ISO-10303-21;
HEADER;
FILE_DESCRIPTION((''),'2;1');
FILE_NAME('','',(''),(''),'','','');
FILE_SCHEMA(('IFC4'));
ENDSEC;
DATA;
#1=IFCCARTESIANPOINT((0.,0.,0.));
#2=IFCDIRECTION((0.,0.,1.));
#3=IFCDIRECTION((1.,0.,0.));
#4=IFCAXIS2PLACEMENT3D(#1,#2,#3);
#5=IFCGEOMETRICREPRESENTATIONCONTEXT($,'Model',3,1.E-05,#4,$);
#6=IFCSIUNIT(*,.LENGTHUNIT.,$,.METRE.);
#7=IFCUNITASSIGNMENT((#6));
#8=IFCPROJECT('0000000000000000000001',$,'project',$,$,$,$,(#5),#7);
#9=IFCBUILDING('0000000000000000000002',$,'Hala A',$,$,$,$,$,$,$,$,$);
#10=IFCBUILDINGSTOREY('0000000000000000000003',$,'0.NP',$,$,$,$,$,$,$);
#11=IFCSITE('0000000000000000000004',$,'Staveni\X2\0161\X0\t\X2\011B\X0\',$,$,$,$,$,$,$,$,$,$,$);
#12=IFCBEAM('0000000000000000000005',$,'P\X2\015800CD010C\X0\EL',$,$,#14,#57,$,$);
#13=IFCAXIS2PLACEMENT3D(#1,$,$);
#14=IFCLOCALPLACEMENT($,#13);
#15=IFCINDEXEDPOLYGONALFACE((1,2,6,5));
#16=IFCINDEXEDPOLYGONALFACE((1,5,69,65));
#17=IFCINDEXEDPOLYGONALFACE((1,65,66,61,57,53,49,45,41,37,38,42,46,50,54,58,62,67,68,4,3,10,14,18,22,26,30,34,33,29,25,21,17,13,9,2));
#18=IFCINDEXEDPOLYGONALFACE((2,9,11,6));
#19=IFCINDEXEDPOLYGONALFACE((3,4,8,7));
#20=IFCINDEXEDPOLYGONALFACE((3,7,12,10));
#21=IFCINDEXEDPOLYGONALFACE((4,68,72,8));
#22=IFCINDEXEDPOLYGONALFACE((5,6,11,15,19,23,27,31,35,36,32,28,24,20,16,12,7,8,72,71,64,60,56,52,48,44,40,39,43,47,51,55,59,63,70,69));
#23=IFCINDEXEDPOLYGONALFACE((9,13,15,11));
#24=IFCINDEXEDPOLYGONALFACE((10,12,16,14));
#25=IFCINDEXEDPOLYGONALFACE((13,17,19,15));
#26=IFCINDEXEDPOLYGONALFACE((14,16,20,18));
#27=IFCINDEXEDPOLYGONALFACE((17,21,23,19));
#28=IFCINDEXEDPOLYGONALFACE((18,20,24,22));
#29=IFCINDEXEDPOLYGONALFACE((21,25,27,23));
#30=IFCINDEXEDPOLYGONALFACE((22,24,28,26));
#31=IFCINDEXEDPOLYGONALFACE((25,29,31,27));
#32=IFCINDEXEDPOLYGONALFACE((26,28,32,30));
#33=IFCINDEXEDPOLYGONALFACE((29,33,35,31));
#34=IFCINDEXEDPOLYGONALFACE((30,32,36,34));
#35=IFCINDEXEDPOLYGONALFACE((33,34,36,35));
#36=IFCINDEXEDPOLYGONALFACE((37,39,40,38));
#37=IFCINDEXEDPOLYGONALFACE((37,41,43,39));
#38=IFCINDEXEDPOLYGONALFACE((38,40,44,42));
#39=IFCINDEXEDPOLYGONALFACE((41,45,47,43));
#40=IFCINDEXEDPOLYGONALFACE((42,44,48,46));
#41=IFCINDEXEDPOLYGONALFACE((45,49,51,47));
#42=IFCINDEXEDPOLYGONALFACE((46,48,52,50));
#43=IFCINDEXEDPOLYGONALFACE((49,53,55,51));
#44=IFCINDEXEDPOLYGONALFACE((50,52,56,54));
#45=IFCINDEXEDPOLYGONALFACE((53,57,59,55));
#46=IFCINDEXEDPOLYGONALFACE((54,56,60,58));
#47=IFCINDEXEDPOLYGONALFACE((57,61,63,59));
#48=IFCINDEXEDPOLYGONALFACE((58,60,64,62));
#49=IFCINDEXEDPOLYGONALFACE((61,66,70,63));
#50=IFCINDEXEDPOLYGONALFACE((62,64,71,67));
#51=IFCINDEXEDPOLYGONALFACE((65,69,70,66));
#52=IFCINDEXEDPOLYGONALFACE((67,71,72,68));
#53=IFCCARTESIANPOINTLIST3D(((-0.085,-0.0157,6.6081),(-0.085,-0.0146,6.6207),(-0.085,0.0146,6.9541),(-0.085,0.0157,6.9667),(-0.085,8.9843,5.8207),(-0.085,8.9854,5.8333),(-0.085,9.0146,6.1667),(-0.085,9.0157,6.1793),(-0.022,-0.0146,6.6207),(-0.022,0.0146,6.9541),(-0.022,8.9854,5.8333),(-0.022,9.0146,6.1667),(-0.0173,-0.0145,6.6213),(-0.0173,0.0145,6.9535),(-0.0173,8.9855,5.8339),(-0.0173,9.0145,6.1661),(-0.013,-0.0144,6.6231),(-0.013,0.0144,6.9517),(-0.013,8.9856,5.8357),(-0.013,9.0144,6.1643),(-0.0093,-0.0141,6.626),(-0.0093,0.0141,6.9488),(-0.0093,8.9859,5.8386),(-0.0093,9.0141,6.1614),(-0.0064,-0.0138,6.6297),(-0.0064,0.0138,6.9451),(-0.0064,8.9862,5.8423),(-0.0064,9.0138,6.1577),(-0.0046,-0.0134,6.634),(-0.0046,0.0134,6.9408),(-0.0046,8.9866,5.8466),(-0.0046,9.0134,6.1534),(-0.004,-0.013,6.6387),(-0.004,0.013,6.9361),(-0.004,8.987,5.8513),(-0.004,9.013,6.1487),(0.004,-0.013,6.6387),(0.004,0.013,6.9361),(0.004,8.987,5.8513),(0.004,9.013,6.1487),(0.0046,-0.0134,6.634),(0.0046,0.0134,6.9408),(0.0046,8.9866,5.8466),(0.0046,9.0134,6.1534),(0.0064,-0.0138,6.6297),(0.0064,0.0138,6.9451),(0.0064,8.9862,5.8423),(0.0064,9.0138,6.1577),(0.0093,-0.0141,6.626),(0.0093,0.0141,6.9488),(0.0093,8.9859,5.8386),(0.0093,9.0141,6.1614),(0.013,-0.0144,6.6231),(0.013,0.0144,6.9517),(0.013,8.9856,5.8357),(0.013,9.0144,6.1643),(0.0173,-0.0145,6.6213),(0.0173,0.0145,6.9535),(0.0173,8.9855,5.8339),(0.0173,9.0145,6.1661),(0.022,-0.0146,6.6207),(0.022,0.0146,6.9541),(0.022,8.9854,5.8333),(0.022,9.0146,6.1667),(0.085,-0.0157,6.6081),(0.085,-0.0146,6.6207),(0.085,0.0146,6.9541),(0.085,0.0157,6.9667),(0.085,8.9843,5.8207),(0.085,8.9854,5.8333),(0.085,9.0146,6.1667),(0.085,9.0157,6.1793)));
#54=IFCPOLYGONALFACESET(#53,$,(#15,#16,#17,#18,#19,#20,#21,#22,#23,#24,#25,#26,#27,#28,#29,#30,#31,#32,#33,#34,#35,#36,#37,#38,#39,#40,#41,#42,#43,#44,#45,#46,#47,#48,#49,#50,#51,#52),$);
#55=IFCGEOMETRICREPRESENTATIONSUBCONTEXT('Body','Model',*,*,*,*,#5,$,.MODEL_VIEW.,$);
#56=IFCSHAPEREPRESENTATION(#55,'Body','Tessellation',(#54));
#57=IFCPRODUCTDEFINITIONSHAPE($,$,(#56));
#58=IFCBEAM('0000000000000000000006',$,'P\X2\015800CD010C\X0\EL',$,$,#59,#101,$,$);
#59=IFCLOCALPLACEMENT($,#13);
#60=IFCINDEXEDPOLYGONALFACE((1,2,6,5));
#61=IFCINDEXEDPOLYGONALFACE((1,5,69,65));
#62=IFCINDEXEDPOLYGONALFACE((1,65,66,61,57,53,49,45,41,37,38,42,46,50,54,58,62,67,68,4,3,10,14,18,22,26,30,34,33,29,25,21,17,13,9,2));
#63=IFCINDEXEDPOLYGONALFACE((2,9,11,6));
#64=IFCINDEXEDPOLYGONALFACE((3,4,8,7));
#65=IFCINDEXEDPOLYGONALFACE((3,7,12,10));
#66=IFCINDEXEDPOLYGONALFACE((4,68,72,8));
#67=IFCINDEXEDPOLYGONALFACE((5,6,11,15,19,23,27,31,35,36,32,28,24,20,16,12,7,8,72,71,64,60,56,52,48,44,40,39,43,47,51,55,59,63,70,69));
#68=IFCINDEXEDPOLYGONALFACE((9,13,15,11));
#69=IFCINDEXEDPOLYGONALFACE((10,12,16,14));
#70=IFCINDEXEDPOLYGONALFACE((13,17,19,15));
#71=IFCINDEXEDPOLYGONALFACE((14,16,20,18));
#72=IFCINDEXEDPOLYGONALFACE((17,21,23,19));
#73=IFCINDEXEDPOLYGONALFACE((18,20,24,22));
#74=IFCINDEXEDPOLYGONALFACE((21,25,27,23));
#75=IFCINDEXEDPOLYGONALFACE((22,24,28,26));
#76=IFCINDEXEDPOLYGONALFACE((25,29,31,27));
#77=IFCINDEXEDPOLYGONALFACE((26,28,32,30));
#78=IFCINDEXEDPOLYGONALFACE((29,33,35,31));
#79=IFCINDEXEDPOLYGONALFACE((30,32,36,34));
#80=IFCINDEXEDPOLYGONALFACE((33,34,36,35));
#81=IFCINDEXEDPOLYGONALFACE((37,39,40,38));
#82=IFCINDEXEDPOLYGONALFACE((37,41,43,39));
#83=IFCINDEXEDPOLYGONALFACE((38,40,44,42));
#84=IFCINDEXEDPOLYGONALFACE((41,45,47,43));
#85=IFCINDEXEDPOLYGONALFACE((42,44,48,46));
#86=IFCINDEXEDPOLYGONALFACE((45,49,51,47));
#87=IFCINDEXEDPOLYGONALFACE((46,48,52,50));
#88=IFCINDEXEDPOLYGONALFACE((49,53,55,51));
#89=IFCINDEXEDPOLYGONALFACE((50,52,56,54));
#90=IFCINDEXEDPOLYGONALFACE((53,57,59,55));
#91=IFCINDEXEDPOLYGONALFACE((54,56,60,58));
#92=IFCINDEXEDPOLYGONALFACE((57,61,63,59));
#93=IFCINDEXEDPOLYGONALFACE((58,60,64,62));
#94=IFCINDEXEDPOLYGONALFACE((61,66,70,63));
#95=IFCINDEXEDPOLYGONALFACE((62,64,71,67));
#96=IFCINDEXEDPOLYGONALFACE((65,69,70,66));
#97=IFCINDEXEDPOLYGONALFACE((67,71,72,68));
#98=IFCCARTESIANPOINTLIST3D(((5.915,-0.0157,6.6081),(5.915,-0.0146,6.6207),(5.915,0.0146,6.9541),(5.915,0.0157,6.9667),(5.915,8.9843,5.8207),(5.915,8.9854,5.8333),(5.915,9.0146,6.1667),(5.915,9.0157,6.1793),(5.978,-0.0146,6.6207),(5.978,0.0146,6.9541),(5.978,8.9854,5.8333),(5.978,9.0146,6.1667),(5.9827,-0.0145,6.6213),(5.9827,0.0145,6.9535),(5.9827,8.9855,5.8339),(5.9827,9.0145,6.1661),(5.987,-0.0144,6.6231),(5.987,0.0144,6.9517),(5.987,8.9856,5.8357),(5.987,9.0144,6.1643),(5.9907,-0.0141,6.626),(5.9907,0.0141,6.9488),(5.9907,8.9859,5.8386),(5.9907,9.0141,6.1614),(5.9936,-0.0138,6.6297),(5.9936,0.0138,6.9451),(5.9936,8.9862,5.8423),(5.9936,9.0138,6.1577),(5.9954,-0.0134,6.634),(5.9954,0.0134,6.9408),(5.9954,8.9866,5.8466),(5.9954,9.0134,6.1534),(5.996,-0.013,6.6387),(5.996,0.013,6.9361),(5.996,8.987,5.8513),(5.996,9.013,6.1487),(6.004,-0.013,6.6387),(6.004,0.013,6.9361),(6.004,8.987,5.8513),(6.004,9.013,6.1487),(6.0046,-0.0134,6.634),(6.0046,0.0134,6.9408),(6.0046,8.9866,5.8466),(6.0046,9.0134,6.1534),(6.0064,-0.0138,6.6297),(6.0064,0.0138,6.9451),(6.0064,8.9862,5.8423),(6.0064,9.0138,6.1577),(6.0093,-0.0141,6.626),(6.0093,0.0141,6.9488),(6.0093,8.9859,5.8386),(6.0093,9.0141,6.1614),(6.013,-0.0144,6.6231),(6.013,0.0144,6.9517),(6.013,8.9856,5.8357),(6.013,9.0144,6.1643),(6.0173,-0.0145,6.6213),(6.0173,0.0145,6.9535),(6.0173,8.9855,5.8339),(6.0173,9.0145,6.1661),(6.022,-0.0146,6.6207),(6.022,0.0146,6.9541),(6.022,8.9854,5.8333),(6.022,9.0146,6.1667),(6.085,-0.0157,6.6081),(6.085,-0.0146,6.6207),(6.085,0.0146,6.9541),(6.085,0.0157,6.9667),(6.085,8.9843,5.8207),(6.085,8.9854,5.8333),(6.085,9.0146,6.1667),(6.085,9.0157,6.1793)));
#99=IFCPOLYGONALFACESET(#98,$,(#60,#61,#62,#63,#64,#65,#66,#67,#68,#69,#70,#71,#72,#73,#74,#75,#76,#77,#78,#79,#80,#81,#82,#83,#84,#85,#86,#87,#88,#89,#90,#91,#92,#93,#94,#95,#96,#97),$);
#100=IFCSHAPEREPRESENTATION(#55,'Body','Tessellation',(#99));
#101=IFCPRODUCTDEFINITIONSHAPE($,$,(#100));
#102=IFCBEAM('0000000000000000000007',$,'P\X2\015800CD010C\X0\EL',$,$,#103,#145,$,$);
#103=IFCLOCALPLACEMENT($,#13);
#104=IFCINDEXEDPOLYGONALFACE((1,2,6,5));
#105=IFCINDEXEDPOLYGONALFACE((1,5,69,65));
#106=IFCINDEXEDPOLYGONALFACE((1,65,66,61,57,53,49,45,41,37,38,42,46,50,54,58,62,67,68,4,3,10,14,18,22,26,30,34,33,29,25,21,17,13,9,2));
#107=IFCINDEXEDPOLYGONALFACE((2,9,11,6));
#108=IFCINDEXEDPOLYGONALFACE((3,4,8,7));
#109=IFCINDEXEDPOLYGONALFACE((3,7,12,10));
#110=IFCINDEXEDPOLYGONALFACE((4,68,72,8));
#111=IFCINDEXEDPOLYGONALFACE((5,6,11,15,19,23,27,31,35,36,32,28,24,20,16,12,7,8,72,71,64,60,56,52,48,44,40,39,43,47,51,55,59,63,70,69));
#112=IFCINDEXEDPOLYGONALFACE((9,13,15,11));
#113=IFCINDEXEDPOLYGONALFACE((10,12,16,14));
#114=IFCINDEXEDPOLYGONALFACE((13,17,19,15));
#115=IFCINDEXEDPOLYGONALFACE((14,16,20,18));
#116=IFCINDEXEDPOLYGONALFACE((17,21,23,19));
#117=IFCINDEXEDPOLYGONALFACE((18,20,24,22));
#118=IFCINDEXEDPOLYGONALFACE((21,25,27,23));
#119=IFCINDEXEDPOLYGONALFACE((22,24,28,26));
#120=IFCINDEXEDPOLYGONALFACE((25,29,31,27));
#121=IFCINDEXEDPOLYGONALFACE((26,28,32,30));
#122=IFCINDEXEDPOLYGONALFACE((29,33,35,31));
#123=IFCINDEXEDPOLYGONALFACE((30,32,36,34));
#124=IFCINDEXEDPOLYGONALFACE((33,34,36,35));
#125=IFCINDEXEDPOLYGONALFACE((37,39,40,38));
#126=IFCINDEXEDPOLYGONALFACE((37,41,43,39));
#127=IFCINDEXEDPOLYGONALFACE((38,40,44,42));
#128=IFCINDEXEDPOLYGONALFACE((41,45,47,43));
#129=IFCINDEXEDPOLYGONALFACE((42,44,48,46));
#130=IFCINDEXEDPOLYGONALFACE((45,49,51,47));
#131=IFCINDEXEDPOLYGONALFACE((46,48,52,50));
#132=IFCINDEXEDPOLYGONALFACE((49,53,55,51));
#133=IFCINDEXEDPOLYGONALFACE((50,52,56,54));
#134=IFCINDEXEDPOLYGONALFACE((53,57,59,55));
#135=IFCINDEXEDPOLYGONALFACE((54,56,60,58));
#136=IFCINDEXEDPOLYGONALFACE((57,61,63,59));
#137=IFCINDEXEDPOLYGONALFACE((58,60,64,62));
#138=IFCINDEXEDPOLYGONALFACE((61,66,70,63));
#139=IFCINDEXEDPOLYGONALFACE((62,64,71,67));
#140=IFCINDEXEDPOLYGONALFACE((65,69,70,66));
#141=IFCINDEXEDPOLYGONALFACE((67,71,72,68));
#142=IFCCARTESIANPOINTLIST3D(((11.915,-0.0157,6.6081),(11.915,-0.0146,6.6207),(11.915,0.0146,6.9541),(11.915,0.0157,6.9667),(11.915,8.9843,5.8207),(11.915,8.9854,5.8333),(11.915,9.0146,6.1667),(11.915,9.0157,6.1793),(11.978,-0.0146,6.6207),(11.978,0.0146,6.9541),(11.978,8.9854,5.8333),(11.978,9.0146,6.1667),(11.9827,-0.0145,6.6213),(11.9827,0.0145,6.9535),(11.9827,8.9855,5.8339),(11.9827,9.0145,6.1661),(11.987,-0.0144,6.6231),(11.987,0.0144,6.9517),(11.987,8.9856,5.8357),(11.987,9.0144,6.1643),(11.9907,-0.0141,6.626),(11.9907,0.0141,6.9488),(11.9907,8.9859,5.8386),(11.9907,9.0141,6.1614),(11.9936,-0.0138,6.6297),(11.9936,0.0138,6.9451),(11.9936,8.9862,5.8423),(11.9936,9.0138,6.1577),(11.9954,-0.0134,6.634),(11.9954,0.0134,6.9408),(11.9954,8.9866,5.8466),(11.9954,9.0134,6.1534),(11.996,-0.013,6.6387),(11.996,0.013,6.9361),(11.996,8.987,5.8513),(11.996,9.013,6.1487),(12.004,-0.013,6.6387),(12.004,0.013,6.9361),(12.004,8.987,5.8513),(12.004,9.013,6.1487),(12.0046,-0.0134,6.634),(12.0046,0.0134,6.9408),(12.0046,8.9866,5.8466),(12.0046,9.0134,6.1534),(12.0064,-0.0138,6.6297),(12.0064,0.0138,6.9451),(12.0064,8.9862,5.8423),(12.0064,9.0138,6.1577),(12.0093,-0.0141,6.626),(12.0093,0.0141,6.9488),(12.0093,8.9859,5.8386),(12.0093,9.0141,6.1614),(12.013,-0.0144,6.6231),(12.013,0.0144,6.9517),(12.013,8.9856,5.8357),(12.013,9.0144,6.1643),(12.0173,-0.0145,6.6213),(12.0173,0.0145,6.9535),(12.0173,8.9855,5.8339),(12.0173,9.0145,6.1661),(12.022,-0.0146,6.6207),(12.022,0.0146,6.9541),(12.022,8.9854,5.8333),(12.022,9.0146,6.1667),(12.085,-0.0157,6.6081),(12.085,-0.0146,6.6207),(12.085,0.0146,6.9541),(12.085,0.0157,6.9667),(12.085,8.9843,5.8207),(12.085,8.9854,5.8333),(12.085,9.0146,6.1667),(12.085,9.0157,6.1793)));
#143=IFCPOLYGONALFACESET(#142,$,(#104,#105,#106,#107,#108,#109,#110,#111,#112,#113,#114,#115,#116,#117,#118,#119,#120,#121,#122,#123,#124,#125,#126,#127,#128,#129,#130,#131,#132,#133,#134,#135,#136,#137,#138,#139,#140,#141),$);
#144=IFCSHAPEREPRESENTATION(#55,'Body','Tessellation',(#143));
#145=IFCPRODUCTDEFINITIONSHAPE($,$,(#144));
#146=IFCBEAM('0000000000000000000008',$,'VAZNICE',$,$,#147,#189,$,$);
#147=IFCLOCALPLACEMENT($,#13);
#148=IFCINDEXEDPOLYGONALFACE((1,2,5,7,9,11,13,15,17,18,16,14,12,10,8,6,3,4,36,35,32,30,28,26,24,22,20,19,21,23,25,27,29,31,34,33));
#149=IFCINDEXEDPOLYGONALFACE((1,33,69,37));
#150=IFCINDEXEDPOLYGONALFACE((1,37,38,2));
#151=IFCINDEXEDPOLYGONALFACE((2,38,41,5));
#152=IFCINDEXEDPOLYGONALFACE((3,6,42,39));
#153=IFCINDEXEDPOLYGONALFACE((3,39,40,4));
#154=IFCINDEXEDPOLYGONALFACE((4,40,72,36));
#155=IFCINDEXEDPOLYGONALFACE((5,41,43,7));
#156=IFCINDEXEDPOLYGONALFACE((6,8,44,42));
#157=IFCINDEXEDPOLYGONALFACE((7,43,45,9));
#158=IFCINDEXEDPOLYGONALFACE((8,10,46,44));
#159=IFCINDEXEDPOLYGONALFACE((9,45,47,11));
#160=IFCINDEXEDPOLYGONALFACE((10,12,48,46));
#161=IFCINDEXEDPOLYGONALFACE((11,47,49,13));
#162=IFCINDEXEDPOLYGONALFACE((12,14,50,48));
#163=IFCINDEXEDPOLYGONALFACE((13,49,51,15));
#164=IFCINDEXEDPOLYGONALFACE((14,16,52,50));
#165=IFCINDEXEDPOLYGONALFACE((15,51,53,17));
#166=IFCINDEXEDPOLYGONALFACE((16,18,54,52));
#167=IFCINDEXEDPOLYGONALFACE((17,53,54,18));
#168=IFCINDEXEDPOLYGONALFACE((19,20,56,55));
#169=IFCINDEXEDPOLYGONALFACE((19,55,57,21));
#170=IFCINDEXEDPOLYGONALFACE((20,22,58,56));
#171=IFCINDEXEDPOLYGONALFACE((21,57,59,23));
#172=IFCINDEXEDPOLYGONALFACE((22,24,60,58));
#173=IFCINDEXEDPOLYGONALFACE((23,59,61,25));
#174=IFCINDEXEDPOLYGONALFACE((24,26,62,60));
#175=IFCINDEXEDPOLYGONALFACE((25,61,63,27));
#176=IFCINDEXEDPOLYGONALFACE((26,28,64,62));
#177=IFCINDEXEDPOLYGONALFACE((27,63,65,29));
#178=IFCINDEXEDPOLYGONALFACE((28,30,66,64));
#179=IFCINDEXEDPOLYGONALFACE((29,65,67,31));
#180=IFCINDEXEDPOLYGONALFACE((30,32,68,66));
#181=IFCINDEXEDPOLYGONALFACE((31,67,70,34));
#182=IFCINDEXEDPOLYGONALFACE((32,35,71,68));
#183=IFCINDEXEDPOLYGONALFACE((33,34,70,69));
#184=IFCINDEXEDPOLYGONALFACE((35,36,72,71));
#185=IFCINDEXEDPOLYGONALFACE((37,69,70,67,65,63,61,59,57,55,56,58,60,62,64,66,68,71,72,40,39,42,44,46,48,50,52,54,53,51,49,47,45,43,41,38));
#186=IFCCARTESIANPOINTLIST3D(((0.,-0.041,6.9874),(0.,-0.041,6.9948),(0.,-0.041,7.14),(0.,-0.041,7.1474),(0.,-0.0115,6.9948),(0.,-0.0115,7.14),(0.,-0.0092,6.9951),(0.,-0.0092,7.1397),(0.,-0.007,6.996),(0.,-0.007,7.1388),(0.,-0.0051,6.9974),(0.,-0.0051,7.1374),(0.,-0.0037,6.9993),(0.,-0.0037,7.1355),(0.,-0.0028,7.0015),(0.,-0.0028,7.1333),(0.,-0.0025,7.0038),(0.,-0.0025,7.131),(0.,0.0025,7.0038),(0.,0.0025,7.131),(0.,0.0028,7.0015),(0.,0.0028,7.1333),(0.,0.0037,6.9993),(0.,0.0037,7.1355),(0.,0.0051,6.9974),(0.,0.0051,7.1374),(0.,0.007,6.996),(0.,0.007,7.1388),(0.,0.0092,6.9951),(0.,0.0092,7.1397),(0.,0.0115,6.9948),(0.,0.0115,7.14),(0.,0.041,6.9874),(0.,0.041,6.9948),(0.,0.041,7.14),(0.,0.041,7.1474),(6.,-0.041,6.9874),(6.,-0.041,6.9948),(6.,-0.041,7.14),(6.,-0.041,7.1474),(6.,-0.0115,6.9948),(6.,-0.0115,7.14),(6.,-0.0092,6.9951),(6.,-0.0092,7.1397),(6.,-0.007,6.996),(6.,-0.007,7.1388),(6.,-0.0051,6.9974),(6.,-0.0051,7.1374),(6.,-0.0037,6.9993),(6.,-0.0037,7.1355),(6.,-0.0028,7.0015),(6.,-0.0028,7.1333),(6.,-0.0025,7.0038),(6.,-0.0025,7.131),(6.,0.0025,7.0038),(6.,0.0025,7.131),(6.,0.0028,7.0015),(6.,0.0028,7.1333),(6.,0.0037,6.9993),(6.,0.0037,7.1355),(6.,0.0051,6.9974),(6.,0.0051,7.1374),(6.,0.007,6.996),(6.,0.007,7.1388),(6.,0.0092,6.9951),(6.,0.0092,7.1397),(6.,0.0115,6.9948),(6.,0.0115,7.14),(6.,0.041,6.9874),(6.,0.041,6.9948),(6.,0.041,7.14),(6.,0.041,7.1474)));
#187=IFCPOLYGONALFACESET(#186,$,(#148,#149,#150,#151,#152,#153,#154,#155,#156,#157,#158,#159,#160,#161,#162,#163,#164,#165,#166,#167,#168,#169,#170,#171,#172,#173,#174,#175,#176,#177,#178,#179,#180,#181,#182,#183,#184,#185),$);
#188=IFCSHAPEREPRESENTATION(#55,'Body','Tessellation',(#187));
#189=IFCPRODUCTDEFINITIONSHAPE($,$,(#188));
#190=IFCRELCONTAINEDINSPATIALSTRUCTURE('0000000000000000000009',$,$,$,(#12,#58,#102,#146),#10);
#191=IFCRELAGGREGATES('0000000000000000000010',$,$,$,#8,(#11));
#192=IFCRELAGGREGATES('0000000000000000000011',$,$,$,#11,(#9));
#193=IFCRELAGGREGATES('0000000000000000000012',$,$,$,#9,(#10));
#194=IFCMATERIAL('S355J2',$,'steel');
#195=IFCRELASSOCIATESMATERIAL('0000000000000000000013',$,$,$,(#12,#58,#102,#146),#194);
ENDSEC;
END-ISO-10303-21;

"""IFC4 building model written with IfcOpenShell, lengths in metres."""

from ifc_helpers import new_model, si_unit, frame, origin_with_axes, place, context, subcontext, project, spatial, i_section, extrude, material, element, save


model = new_model("IFC4")

# Units and contexts
model_context = context("Model", 3, precision=1e-05, world=origin_with_axes())
body_context = subcontext(model_context, "Body", "Model", "MODEL_VIEW")
ifc_project = project(units=[si_unit("LENGTHUNIT", "METRE")], contexts=[model_context])

# Site, building, storey
site = spatial("IfcSite", under=ifc_project, Name="Staveniště")
building = spatial("IfcBuilding", under=site, Name="Hala A")
storey = spatial("IfcBuildingStorey", under=building, Name="0.NP")

# Shared definitions
ifc_material = material(Name="S355J2", Category="steel")

# Beams
for number, where, z_axis, x_axis, name in (
    (1, (0.0, 9.0, 6.0), (0.0, -0.996195, 0.087156), (1.0, 0.0, 0.0), "PŘÍČEL"),
    (2, (6.0, 9.0, 6.0), (0.0, -0.996195, 0.087156), (1.0, 0.0, 0.0), "PŘÍČEL"),
    (3, (12.0, 9.0, 6.0), (0.0, -0.996195, 0.087156), (1.0, 0.0, 0.0), "PŘÍČEL"),
):
    element("IfcBeam", number, at=place(None, frame(where, z_axis=z_axis, x_axis=x_axis)), inside=storey, material=ifc_material, Name=name, context=body_context, shape_type="SweptSolid", body=[
        extrude(i_section(OverallWidth=0.17, OverallDepth=0.36, WebThickness=0.008, FlangeThickness=0.0127, FilletRadius=0.018), origin_with_axes(), (0.0, 0.0, 1.0), 9.0344),
    ])
for number, where, z_axis, x_axis, name in (
    (4, (0.0, 0.0, 7.0674), (1.0, 0.0, 0.0), (0.0, 1.0, 0.0), "VAZNICE"),
):
    element("IfcBeam", number, at=place(None, frame(where, z_axis=z_axis, x_axis=x_axis)), inside=storey, material=ifc_material, Name=name, context=body_context, shape_type="SweptSolid", body=[
        extrude(i_section(OverallWidth=0.082, OverallDepth=0.16, WebThickness=0.005, FlangeThickness=0.0074, FilletRadius=0.009), origin_with_axes(), (0.0, 0.0, 1.0), 6.0),
    ])

save(model, "model.ifc")
